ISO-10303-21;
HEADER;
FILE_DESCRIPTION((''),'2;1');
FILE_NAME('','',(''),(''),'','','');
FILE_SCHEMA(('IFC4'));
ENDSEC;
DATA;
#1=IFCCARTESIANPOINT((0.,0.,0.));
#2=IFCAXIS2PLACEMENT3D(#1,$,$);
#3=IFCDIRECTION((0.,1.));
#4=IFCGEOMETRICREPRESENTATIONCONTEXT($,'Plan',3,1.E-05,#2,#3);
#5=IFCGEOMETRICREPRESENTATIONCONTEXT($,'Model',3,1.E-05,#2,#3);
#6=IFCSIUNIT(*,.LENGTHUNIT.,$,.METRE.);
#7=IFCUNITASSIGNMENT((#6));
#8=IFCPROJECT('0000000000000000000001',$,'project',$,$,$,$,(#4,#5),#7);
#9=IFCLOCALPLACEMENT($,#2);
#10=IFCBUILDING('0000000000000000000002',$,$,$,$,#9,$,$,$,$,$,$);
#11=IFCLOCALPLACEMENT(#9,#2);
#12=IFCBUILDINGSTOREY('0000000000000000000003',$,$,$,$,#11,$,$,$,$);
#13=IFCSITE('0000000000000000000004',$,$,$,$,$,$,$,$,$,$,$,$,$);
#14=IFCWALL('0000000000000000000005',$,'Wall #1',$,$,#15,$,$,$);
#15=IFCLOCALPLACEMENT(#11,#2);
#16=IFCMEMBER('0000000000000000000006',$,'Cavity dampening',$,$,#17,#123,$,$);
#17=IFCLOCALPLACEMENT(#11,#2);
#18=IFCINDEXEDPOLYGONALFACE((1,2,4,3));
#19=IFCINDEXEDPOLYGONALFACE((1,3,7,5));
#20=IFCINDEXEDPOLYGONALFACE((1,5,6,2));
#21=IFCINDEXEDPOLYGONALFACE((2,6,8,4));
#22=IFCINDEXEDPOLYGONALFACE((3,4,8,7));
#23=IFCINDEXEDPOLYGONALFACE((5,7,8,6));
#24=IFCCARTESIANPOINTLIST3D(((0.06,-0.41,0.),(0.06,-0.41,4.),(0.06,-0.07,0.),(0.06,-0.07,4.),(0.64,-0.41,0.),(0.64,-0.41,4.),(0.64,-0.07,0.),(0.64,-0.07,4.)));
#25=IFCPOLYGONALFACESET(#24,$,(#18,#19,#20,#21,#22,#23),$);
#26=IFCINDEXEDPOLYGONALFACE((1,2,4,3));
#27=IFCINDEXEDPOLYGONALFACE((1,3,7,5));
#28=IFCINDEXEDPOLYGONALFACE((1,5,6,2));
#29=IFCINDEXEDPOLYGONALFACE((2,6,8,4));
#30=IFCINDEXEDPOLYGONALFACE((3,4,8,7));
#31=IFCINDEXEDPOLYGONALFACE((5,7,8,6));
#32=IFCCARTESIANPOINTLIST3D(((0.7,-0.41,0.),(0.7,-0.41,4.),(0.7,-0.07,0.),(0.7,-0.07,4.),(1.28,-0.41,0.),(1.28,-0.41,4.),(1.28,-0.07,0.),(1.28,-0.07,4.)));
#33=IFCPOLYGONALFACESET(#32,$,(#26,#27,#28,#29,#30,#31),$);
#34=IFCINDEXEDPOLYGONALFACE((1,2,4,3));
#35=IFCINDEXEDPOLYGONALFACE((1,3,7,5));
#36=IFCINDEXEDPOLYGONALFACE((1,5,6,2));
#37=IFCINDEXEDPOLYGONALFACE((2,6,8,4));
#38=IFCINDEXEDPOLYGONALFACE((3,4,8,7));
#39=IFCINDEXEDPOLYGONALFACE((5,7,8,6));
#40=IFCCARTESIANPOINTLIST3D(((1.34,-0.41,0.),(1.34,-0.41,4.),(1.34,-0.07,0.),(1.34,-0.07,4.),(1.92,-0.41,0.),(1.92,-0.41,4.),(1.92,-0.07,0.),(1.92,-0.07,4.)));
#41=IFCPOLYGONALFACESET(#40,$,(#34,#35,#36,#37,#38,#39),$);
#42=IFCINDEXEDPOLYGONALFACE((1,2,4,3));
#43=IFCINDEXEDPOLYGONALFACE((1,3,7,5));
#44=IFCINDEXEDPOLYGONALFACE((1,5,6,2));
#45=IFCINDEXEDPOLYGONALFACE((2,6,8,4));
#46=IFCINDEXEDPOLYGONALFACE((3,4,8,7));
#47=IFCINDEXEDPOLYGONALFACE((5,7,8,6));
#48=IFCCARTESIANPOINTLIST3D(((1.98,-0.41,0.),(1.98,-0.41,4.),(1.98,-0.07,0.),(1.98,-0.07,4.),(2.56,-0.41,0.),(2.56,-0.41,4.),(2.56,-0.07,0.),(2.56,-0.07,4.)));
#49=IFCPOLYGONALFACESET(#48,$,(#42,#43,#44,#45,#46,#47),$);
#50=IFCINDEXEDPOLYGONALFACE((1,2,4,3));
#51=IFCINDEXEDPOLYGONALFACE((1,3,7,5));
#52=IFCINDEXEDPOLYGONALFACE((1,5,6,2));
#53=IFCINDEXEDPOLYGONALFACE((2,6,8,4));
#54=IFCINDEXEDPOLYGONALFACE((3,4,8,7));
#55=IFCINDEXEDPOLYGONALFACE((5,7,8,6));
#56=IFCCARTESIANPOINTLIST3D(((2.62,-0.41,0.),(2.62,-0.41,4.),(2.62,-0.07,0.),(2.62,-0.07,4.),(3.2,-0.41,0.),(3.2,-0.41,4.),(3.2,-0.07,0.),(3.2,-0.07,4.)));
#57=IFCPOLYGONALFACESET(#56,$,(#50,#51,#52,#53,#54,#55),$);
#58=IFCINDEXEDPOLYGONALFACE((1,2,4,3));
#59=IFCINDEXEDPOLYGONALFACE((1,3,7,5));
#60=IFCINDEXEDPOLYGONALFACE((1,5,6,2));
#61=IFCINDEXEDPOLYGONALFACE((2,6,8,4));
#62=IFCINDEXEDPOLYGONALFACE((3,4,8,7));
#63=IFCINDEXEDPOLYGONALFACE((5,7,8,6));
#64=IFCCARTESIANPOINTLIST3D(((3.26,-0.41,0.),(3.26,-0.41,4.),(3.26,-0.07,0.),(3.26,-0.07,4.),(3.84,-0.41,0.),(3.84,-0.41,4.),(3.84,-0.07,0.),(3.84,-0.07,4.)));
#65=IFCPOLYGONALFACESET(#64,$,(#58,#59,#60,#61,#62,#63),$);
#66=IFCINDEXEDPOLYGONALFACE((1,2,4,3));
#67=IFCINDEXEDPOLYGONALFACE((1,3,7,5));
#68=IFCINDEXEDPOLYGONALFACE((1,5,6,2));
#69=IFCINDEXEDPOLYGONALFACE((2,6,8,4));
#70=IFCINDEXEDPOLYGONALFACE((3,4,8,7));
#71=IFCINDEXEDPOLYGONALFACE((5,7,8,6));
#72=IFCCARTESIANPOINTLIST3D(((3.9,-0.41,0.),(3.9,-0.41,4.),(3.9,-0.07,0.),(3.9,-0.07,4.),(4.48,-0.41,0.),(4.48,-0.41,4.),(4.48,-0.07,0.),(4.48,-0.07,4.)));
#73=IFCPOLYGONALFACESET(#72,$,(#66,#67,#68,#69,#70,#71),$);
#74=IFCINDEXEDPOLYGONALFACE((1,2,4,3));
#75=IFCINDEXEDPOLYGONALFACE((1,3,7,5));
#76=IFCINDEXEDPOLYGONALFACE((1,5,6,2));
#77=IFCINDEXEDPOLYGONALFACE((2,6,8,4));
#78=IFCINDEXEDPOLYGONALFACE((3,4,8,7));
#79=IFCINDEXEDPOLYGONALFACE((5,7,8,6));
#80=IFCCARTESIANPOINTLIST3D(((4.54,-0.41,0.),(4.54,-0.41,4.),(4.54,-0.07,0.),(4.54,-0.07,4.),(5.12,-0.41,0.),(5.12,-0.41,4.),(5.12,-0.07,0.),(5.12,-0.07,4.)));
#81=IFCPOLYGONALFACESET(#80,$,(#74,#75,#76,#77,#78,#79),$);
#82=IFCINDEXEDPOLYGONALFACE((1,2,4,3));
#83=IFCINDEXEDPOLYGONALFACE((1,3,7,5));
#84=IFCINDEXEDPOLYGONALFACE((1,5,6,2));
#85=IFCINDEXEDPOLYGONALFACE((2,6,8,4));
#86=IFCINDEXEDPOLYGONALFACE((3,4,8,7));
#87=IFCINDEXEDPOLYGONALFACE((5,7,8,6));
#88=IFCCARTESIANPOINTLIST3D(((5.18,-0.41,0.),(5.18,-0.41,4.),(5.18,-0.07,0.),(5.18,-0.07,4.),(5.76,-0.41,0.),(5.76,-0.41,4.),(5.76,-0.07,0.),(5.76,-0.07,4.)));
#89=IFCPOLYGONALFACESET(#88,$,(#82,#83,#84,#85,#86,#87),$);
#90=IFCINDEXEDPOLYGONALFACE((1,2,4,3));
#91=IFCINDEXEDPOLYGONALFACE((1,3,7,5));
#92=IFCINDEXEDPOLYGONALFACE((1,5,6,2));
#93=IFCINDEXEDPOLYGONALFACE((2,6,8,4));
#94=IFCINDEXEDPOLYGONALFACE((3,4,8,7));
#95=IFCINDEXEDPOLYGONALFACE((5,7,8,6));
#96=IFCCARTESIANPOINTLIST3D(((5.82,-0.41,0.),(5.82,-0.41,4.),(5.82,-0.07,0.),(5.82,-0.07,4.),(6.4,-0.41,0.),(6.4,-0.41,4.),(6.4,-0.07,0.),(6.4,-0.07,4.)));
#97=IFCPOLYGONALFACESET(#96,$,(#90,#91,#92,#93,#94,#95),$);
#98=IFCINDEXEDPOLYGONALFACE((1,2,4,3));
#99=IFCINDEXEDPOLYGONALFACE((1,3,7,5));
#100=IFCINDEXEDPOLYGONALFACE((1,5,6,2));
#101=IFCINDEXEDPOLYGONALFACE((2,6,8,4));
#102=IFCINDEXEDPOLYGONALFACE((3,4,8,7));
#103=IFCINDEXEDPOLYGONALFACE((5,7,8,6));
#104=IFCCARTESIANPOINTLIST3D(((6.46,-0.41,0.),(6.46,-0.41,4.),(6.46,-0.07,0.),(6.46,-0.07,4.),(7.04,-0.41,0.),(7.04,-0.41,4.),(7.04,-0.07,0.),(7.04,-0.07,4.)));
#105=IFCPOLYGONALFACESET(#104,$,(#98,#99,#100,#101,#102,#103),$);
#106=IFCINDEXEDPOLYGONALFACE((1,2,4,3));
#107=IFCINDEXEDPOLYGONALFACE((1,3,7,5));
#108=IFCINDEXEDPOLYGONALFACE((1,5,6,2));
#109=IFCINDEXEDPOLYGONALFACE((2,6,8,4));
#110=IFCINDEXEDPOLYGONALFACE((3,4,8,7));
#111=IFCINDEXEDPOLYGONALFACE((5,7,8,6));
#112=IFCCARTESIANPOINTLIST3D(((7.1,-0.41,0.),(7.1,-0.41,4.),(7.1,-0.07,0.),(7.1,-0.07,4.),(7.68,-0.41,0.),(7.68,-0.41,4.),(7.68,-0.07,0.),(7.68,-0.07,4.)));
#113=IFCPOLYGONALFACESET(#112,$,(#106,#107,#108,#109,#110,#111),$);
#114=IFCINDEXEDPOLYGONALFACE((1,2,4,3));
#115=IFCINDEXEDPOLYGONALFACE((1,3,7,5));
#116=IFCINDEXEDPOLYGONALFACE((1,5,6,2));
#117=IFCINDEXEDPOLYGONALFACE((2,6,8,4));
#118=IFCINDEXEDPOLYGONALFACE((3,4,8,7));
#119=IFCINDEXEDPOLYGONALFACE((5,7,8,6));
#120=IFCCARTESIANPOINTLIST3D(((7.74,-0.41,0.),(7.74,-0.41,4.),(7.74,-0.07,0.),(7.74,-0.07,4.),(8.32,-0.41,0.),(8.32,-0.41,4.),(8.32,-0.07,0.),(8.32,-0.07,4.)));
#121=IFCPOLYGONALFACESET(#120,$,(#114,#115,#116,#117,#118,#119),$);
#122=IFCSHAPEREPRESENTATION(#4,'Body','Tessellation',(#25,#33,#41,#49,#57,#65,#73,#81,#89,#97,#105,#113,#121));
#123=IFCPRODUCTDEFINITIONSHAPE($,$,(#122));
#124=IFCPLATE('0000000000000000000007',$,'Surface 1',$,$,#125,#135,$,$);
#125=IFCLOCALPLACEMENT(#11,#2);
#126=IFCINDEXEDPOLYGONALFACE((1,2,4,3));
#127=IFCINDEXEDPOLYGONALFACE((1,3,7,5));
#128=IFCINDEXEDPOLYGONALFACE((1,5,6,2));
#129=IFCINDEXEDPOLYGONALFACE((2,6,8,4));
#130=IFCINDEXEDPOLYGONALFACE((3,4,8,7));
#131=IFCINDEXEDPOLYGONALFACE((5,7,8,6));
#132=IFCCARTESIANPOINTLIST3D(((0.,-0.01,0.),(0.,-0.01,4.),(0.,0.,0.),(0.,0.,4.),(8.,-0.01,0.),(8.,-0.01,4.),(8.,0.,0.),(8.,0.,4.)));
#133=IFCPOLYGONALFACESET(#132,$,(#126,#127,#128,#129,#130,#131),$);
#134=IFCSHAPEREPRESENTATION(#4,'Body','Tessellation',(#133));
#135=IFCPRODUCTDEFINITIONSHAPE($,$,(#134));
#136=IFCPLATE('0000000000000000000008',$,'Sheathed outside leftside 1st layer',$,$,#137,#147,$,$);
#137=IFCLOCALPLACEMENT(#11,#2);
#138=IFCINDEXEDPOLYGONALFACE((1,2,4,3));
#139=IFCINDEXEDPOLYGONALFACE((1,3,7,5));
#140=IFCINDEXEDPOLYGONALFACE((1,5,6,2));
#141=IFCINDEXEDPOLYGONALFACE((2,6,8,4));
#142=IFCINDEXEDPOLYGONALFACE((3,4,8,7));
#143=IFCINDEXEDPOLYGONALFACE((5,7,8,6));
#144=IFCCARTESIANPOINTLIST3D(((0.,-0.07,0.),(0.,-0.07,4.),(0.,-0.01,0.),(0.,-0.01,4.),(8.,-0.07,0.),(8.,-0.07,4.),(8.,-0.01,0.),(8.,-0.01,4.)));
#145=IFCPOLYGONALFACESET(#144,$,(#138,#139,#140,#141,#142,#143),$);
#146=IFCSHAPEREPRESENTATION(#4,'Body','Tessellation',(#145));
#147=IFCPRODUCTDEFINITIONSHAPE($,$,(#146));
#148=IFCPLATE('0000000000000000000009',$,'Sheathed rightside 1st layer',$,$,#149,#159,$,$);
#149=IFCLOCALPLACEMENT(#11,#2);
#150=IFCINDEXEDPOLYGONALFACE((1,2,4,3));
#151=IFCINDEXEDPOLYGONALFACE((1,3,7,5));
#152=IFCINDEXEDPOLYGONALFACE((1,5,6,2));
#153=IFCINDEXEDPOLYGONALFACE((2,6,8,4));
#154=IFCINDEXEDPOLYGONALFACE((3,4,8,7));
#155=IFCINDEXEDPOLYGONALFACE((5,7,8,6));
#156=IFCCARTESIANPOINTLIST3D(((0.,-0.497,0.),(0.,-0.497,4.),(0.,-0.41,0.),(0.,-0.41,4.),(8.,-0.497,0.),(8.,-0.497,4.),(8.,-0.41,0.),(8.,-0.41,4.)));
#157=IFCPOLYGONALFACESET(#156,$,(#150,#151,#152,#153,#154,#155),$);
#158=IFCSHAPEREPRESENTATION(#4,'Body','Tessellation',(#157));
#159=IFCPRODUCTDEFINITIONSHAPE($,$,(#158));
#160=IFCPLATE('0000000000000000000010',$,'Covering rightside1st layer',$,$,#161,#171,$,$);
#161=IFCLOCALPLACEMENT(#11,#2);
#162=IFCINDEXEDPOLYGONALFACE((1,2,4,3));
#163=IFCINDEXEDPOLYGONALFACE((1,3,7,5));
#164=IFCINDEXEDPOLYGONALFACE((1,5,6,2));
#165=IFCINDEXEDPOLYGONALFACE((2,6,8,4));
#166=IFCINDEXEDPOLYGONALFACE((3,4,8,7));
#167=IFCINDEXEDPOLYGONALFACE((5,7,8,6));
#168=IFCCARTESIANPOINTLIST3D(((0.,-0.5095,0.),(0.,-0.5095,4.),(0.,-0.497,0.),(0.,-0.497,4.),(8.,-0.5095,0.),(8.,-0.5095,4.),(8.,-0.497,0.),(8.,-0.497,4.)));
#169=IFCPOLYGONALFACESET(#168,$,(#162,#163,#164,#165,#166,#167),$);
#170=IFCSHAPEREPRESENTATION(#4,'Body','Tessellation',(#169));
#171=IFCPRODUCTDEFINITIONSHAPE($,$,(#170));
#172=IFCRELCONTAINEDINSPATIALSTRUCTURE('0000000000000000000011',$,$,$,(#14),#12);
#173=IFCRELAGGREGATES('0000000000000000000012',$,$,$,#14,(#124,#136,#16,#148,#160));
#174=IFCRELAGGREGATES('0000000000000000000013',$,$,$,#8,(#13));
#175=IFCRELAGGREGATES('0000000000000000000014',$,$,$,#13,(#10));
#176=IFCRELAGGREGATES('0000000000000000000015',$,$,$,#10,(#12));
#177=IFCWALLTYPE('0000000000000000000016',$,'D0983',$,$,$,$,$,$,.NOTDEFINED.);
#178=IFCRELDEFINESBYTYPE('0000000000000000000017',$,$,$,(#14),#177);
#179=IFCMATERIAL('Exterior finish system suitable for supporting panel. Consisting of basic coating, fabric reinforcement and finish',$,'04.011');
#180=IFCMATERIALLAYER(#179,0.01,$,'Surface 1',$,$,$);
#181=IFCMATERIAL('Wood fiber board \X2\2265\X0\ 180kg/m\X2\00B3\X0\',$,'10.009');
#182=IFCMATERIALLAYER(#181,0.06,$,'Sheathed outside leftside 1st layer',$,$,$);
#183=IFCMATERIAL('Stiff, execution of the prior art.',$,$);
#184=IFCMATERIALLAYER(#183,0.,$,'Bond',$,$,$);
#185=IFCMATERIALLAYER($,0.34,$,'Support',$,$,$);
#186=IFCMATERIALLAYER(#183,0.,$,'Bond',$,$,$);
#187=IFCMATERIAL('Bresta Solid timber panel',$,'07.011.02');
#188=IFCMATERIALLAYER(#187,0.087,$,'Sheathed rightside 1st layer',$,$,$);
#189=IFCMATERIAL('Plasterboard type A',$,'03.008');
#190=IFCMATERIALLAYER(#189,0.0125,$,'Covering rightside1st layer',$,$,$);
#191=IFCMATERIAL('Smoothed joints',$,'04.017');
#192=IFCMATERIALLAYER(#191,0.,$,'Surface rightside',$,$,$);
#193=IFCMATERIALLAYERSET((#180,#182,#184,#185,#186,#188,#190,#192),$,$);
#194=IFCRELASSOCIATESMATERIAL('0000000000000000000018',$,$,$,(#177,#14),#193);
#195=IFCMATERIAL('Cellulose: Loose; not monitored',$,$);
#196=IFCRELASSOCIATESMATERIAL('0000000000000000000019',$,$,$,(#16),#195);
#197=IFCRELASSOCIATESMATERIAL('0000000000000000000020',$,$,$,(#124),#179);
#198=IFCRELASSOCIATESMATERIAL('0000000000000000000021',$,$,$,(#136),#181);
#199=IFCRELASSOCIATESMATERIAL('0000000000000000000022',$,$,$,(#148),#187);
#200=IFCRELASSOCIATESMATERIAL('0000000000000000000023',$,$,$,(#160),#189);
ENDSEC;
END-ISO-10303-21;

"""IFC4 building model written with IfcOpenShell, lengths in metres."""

from ifc_helpers import new_model, si_unit, direction, frame, frame_2d, origin, origin_with_axes, place, context, project, spatial, rectangle, extrude, material, layer, layer_set, type_object, element, aggregate, save


model = new_model("IFC4")

# Units and contexts
plan_context = context("Plan", 3, precision=1e-05, world=origin(), true_north=direction((0.0, 1.0)))
model_context = context("Model", 3, precision=1e-05, world=origin(), true_north=direction((0.0, 1.0)))
ifc_project = project(units=[si_unit("LENGTHUNIT", "METRE")], contexts=[plan_context, model_context])

# Site, building, storey
site = spatial("IfcSite", under=ifc_project)
building_placement = place(None, origin())
building = spatial("IfcBuilding", under=site, at=building_placement)
storey_placement = place(building_placement, origin())
storey = spatial("IfcBuildingStorey", under=building, at=storey_placement)

# Wall, member, plates
ifc_material_1 = material(Name="Exterior finish system suitable for supporting panel. Consisting of basic coating, fabric reinforcement and finish", Category="04.011")
ifc_layer_1 = layer(ifc_material_1, 0.01, Name="Surface 1")
ifc_material_2 = material(Name="Wood fiber board ≥ 180kg/m³", Category="10.009")
ifc_layer_2 = layer(ifc_material_2, 0.06, Name="Sheathed outside leftside 1st layer")
ifc_material_3 = material(Name="Stiff, execution of the prior art.")
ifc_layer_3 = layer(ifc_material_3, 0.0, Name="Bond")
ifc_layer_4 = layer(None, 0.34, Name="Support")
ifc_layer_5 = layer(ifc_material_3, 0.0, Name="Bond")
ifc_material_4 = material(Name="Bresta Solid timber panel", Category="07.011.02")
ifc_layer_6 = layer(ifc_material_4, 0.087, Name="Sheathed rightside 1st layer")
ifc_material_5 = material(Name="Plasterboard type A", Category="03.008")
ifc_layer_7 = layer(ifc_material_5, 0.0125, Name="Covering rightside1st layer")
ifc_material_6 = material(Name="Smoothed joints", Category="04.017")
ifc_layer_8 = layer(ifc_material_6, 0.0, Name="Surface rightside")
ifc_layer_set = layer_set([ifc_layer_1, ifc_layer_2, ifc_layer_3, ifc_layer_4, ifc_layer_5, ifc_layer_6, ifc_layer_7, ifc_layer_8])
wall_type = type_object("IfcWallType", Name="D0983", PredefinedType="NOTDEFINED", material=ifc_layer_set)
wall_placement = place(None, frame((0.0, 0.0, 0.0), z_axis=(0.0, -1.0, 0.0), x_axis=(1.0, 0.0, 0.0)))
wall = element("IfcWall", 1, at=wall_placement, inside=storey, type_object=wall_type, material=ifc_layer_set, Name="Wall #1")
ifc_material_7 = material(Name="Cellulose: Loose; not monitored")
member_1_placement = place(wall_placement, origin())
member_1 = element("IfcMember", 2, at=member_1_placement, material=ifc_material_7, Name="Cavity dampening", context=plan_context, shape_type="SweptSolid", body=[
    extrude(rectangle(XDim=0.58, YDim=0.34, at=frame_2d((0.29, 0.17), x_axis=(1.0, 0.0))), frame((0.06, 4.0, 0.07), z_axis=(0.0, -1.0, 0.0), x_axis=(1.0, 0.0, 0.0)), (0.0, 0.0, 1.0), 4.0),
    extrude(rectangle(XDim=0.58, YDim=0.34, at=frame_2d((0.29, 0.17), x_axis=(1.0, 0.0))), frame((0.7, 4.0, 0.07), z_axis=(0.0, -1.0, 0.0), x_axis=(1.0, 0.0, 0.0)), (0.0, 0.0, 1.0), 4.0),
    extrude(rectangle(XDim=0.58, YDim=0.34, at=frame_2d((0.29, 0.17), x_axis=(1.0, 0.0))), frame((1.34, 4.0, 0.07), z_axis=(0.0, -1.0, 0.0), x_axis=(1.0, 0.0, 0.0)), (0.0, 0.0, 1.0), 4.0),
    extrude(rectangle(XDim=0.58, YDim=0.34, at=frame_2d((0.29, 0.17), x_axis=(1.0, 0.0))), frame((1.98, 4.0, 0.07), z_axis=(0.0, -1.0, 0.0), x_axis=(1.0, 0.0, 0.0)), (0.0, 0.0, 1.0), 4.0),
    extrude(rectangle(XDim=0.58, YDim=0.34, at=frame_2d((0.29, 0.17), x_axis=(1.0, 0.0))), frame((2.62, 4.0, 0.07), z_axis=(0.0, -1.0, 0.0), x_axis=(1.0, 0.0, 0.0)), (0.0, 0.0, 1.0), 4.0),
    extrude(rectangle(XDim=0.58, YDim=0.34, at=frame_2d((0.29, 0.17), x_axis=(1.0, 0.0))), frame((3.26, 4.0, 0.07), z_axis=(0.0, -1.0, 0.0), x_axis=(1.0, 0.0, 0.0)), (0.0, 0.0, 1.0), 4.0),
    extrude(rectangle(XDim=0.58, YDim=0.34, at=frame_2d((0.29, 0.17), x_axis=(1.0, 0.0))), frame((3.9, 4.0, 0.07), z_axis=(0.0, -1.0, 0.0), x_axis=(1.0, 0.0, 0.0)), (0.0, 0.0, 1.0), 4.0),
    extrude(rectangle(XDim=0.58, YDim=0.34, at=frame_2d((0.29, 0.17), x_axis=(1.0, 0.0))), frame((4.54, 4.0, 0.07), z_axis=(0.0, -1.0, 0.0), x_axis=(1.0, 0.0, 0.0)), (0.0, 0.0, 1.0), 4.0),
    extrude(rectangle(XDim=0.58, YDim=0.34, at=frame_2d((0.29, 0.17), x_axis=(1.0, 0.0))), frame((5.18, 4.0, 0.07), z_axis=(0.0, -1.0, 0.0), x_axis=(1.0, 0.0, 0.0)), (0.0, 0.0, 1.0), 4.0),
    extrude(rectangle(XDim=0.58, YDim=0.34, at=frame_2d((0.29, 0.17), x_axis=(1.0, 0.0))), frame((5.82, 4.0, 0.07), z_axis=(0.0, -1.0, 0.0), x_axis=(1.0, 0.0, 0.0)), (0.0, 0.0, 1.0), 4.0),
    extrude(rectangle(XDim=0.58, YDim=0.34, at=frame_2d((0.29, 0.17), x_axis=(1.0, 0.0))), frame((6.46, 4.0, 0.07), z_axis=(0.0, -1.0, 0.0), x_axis=(1.0, 0.0, 0.0)), (0.0, 0.0, 1.0), 4.0),
    extrude(rectangle(XDim=0.58, YDim=0.34, at=frame_2d((0.29, 0.17), x_axis=(1.0, 0.0))), frame((7.1, 4.0, 0.07), z_axis=(0.0, -1.0, 0.0), x_axis=(1.0, 0.0, 0.0)), (0.0, 0.0, 1.0), 4.0),
    extrude(rectangle(XDim=0.58, YDim=0.34, at=frame_2d((0.29, 0.17), x_axis=(1.0, 0.0))), frame((7.74, 4.0, 0.07), z_axis=(0.0, -1.0, 0.0), x_axis=(1.0, 0.0, 0.0)), (0.0, 0.0, 1.0), 4.0),
])
plate_1_placement = place(wall_placement, origin())
plate_1 = element("IfcPlate", 3, at=plate_1_placement, material=ifc_material_1, Name="Surface 1", context=plan_context, shape_type="SweptSolid", body=[
    extrude(rectangle(XDim=8.0, YDim=4.0, at=frame_2d((4.0, 2.0), x_axis=(1.0, 0.0))), origin_with_axes(), (0.0, 0.0, 1.0), 0.01),
])
plate_2_placement = place(wall_placement, origin())
plate_2 = element("IfcPlate", 4, at=plate_2_placement, material=ifc_material_2, Name="Sheathed outside leftside 1st layer", context=plan_context, shape_type="SweptSolid", body=[
    extrude(rectangle(XDim=8.0, YDim=4.0, at=frame_2d((4.0, 2.0), x_axis=(1.0, 0.0))), frame((0.0, 0.0, 0.01), z_axis=(0.0, 0.0, 1.0), x_axis=(1.0, 0.0, 0.0)), (0.0, 0.0, 1.0), 0.06),
])
plate_3_placement = place(wall_placement, origin())
plate_3 = element("IfcPlate", 5, at=plate_3_placement, material=ifc_material_4, Name="Sheathed rightside 1st layer", context=plan_context, shape_type="SweptSolid", body=[
    extrude(rectangle(XDim=8.0, YDim=4.0, at=frame_2d((4.0, 2.0), x_axis=(1.0, 0.0))), frame((0.0, 0.0, 0.41), z_axis=(0.0, 0.0, 1.0), x_axis=(1.0, 0.0, 0.0)), (0.0, 0.0, 1.0), 0.087),
])
plate_4_placement = place(wall_placement, origin())
plate_4 = element("IfcPlate", 6, at=plate_4_placement, material=ifc_material_5, Name="Covering rightside1st layer", context=plan_context, shape_type="SweptSolid", body=[
    extrude(rectangle(XDim=8.0, YDim=4.0, at=frame_2d((4.0, 2.0), x_axis=(1.0, 0.0))), frame((0.0, 0.0, 0.497), z_axis=(0.0, 0.0, 1.0), x_axis=(1.0, 0.0, 0.0)), (0.0, 0.0, 1.0), 0.0125),
])
aggregate(wall, [plate_1, plate_2, member_1, plate_3, plate_4])

save(model, "model.ifc")
